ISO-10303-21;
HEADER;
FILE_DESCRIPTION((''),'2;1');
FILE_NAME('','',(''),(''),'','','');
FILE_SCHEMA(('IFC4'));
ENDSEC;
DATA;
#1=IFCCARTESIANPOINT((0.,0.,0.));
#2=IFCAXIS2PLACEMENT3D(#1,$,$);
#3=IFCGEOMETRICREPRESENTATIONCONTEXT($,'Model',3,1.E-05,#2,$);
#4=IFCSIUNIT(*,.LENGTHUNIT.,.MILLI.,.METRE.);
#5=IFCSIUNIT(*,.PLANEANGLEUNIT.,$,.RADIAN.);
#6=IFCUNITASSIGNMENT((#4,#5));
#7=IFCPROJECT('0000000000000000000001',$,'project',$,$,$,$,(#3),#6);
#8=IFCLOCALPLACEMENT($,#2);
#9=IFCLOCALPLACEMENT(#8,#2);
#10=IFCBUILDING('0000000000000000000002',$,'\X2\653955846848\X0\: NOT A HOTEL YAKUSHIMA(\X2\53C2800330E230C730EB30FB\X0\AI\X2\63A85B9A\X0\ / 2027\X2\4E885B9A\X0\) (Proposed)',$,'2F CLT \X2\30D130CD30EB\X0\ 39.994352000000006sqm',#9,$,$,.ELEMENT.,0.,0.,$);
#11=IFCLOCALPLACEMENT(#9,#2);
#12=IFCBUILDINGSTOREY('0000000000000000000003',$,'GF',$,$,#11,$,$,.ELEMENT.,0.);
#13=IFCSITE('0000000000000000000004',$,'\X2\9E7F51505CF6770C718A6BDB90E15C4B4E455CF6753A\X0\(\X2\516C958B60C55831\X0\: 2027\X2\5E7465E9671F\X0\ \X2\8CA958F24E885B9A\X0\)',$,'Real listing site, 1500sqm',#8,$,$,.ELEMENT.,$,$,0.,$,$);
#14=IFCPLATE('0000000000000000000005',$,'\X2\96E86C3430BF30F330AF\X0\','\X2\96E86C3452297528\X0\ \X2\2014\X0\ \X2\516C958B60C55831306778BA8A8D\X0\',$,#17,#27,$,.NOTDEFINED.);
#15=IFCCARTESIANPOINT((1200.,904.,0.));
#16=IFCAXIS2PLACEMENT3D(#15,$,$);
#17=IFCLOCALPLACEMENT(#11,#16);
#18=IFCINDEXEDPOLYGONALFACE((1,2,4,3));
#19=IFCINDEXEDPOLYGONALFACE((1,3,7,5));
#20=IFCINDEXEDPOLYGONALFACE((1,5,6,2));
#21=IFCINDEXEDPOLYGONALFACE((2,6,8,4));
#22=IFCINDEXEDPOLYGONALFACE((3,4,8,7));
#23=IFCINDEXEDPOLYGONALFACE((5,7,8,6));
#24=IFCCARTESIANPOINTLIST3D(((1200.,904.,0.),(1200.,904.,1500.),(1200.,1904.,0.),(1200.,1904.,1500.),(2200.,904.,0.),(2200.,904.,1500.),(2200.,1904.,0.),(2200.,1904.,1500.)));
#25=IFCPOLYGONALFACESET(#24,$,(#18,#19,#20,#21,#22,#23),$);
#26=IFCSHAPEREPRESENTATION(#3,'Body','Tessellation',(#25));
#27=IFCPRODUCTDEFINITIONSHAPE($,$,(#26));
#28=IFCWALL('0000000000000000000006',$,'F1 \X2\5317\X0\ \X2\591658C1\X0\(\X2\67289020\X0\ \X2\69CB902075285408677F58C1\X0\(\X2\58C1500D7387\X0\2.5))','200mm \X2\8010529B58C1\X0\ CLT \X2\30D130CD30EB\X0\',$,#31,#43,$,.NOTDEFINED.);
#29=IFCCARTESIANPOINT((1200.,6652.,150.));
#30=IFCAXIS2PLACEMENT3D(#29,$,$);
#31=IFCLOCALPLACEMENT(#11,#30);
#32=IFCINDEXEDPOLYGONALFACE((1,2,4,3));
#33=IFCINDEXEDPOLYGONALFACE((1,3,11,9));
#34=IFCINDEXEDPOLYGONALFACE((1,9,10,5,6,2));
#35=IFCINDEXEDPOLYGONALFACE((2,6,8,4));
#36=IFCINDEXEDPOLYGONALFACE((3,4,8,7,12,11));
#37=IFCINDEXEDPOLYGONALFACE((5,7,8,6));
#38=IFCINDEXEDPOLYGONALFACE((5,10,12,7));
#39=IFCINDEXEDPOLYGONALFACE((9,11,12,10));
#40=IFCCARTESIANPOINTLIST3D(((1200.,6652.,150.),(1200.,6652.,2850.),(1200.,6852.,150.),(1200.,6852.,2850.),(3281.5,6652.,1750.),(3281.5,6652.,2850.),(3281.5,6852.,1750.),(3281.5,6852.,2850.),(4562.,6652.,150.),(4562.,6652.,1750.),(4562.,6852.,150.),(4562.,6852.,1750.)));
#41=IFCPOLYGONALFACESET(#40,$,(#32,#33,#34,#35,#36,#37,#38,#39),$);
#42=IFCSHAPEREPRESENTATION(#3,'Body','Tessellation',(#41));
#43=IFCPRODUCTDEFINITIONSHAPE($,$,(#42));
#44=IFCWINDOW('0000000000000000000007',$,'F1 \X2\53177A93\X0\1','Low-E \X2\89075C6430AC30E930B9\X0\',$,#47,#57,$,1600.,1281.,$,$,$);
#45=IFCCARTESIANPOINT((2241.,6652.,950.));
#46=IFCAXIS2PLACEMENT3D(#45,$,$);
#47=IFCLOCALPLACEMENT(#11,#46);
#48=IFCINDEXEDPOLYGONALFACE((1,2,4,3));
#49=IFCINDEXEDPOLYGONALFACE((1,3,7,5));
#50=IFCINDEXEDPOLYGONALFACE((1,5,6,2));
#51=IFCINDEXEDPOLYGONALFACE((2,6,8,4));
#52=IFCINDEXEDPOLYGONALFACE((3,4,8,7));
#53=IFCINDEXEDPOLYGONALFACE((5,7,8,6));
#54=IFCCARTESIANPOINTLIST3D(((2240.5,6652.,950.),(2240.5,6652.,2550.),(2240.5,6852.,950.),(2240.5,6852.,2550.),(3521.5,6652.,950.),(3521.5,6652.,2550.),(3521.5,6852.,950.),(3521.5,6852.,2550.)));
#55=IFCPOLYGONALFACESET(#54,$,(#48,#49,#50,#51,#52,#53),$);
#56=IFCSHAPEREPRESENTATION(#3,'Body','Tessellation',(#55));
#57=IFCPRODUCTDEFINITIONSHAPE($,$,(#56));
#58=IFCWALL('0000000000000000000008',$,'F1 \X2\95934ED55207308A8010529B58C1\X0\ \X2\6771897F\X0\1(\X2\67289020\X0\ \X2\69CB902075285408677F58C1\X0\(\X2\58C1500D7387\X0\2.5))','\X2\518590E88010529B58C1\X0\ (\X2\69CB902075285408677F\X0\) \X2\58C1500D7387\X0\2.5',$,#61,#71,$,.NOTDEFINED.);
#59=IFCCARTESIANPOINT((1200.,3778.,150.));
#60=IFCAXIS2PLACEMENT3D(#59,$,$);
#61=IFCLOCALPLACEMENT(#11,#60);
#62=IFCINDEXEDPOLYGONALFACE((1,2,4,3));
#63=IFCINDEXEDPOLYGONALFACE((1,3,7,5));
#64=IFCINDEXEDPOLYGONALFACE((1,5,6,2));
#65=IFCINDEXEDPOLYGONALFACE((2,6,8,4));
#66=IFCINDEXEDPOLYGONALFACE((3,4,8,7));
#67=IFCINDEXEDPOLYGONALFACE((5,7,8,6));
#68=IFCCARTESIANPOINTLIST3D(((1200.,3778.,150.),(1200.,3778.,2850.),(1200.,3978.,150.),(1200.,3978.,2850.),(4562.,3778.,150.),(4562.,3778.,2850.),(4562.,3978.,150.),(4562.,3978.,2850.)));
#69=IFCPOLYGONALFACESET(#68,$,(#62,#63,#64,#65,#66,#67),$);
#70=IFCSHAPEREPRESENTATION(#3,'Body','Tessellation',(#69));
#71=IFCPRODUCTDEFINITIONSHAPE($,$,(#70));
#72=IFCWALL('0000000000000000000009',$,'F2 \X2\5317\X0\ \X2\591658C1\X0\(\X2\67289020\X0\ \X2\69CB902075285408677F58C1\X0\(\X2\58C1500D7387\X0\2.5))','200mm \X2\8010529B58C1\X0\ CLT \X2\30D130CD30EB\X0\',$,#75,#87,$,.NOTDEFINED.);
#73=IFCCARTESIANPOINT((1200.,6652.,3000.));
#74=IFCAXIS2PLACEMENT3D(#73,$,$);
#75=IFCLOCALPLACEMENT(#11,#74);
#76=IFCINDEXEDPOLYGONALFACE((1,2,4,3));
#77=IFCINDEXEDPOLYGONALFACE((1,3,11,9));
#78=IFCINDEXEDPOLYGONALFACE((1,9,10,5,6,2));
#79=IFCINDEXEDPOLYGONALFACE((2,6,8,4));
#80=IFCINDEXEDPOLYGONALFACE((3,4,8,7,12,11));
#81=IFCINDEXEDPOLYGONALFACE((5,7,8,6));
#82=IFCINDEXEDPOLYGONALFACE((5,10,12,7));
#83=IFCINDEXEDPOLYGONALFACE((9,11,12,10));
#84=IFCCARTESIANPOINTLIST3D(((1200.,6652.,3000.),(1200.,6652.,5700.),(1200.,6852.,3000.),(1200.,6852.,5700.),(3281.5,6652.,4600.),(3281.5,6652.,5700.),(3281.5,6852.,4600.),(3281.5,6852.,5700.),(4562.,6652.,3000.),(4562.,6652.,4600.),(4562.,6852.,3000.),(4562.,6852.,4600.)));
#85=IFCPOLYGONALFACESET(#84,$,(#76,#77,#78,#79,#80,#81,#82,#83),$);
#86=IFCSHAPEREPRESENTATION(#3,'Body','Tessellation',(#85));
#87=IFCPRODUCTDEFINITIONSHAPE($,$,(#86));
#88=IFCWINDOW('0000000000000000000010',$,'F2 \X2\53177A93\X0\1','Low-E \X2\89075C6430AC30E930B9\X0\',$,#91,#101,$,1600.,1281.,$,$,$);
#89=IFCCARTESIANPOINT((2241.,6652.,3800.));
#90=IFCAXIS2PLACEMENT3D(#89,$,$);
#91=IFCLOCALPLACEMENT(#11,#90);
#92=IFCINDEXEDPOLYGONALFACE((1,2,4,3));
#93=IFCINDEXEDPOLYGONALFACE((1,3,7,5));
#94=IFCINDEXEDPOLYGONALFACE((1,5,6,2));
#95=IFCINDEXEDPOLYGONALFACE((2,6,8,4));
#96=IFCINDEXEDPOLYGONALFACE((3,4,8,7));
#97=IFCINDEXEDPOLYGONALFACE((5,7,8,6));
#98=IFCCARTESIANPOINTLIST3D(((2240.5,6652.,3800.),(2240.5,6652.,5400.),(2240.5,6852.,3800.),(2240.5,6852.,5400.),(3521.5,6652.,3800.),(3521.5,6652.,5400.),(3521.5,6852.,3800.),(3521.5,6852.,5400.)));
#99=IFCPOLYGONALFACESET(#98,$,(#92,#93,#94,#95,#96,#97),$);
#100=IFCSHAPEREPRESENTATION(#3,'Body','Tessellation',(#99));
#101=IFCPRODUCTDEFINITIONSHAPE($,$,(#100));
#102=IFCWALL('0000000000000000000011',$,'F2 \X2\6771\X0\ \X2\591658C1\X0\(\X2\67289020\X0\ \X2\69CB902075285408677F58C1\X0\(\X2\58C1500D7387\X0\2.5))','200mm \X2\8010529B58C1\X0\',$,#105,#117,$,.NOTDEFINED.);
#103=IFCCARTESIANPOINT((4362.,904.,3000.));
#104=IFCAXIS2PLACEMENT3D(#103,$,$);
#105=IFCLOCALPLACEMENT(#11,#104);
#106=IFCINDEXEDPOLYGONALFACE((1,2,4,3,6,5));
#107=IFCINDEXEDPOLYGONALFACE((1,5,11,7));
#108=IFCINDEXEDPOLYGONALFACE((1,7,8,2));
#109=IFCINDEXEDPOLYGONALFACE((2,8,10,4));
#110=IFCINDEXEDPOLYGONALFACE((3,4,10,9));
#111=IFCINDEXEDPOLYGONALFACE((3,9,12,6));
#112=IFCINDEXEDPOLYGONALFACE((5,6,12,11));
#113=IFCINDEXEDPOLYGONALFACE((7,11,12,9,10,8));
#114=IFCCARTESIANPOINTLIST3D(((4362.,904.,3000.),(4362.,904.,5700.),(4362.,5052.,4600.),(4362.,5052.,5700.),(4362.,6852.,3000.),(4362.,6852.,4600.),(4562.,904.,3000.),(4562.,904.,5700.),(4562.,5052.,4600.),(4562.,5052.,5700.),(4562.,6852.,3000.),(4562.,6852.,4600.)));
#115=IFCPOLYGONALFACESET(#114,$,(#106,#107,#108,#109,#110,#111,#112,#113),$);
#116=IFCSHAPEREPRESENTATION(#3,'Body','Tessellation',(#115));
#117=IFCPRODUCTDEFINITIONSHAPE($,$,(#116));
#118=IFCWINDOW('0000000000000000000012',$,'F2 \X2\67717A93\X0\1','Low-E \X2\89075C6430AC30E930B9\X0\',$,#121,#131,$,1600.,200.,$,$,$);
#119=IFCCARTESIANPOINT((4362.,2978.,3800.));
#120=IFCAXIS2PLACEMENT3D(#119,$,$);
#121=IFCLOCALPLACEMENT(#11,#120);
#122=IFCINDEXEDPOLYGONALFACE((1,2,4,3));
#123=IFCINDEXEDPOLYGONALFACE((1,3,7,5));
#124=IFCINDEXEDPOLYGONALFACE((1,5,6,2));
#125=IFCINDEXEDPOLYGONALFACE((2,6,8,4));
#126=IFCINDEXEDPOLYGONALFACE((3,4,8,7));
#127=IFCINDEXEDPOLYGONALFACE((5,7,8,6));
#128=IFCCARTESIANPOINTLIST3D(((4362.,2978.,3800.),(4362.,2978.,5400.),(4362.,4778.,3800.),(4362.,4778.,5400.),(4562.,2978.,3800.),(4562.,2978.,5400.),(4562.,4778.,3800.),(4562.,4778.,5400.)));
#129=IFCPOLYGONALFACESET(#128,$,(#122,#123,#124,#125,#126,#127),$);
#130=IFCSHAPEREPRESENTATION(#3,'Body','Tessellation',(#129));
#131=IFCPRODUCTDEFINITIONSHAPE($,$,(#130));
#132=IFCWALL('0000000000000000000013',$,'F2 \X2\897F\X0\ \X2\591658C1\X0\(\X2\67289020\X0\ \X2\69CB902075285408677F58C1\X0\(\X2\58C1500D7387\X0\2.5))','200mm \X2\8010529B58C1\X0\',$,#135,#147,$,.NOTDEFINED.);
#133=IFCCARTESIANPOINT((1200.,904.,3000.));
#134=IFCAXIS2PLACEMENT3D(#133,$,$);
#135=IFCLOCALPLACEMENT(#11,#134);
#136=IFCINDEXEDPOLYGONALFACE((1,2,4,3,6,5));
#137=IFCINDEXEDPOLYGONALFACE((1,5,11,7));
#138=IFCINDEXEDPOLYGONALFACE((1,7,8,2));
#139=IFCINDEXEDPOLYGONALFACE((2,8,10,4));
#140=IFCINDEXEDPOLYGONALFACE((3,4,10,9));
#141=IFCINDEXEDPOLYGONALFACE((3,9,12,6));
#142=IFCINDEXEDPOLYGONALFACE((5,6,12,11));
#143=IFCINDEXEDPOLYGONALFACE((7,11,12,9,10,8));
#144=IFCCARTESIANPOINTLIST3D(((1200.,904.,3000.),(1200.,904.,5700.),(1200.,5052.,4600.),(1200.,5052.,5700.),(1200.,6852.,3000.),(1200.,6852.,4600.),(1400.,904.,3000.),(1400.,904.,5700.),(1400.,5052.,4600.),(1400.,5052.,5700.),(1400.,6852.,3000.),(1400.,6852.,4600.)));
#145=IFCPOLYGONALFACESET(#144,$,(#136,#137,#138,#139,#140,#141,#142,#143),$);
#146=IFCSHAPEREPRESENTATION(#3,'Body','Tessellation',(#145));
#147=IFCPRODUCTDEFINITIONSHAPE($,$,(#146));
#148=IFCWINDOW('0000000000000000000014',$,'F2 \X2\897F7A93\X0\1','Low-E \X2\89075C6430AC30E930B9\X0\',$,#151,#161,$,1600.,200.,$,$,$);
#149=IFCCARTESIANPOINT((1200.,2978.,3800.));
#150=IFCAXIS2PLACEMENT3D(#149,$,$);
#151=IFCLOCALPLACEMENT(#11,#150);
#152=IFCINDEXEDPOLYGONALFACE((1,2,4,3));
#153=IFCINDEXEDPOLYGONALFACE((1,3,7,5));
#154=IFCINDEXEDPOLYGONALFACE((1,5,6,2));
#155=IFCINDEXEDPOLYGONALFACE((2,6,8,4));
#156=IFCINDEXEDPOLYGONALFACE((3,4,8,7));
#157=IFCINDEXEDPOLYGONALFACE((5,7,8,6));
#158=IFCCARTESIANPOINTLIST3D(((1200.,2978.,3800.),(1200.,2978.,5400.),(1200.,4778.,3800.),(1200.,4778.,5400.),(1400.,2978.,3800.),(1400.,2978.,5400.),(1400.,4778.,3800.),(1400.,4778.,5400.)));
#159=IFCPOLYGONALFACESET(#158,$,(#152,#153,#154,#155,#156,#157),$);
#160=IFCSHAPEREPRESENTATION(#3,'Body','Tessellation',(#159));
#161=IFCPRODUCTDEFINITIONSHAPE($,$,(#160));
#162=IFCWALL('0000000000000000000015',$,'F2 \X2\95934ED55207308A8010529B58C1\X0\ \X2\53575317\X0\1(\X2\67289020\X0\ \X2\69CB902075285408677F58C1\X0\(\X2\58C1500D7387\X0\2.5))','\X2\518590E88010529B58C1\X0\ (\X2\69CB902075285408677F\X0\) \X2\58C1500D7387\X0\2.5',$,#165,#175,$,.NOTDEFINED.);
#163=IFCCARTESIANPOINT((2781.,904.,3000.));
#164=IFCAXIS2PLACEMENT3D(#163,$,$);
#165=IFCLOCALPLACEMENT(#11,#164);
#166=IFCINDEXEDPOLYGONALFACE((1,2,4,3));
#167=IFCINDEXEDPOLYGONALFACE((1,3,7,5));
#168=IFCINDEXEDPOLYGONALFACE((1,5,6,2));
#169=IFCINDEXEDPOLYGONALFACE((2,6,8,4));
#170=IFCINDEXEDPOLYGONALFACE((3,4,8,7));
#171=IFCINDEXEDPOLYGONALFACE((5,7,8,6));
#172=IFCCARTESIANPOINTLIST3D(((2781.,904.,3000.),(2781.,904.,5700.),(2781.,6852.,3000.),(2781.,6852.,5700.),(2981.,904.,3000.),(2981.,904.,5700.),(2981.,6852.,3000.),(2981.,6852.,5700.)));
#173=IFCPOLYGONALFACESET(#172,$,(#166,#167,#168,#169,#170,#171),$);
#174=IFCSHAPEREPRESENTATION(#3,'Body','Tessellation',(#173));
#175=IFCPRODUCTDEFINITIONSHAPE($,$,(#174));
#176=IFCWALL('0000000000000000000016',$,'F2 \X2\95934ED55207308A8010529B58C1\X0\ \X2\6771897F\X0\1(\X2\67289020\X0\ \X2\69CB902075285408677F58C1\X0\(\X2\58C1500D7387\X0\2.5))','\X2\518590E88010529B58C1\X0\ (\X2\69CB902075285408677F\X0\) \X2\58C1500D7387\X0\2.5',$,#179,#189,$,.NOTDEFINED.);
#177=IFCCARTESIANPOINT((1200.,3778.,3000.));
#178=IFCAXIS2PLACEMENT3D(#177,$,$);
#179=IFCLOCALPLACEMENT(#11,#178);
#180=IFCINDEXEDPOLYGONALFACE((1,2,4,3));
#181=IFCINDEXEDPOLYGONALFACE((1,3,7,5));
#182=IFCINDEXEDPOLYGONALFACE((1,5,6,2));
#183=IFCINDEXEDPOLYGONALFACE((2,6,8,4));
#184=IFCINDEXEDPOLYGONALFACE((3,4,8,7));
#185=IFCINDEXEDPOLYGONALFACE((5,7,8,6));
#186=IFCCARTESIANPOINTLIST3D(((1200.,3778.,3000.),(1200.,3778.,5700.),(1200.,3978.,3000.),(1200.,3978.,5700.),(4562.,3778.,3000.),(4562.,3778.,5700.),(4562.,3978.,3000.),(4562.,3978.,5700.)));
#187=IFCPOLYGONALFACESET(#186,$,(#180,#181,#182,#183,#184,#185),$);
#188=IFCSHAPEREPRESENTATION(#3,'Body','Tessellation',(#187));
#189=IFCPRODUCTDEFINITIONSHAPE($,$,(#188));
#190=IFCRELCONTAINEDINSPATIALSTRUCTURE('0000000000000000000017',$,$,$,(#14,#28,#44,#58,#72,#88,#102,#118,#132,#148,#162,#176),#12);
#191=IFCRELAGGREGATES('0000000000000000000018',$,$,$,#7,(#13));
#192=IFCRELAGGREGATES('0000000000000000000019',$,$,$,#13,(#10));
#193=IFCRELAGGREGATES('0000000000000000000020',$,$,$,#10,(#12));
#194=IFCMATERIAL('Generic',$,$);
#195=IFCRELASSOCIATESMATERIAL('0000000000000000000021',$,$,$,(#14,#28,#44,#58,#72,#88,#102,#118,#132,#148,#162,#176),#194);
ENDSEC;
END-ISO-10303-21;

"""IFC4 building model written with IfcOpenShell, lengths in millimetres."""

from ifc_helpers import new_model, si_unit, frame, frame_2d, origin, place, context, project, spatial, rectangle, extrude, material, element, fill, save


model = new_model("IFC4")

# Units and contexts
model_context = context("Model", 3, precision=1e-05, world=origin())
ifc_project = project(units=[si_unit("LENGTHUNIT", "METRE", prefix="MILLI"), si_unit("PLANEANGLEUNIT", "RADIAN")], contexts=[model_context])

# Site, building, storey
site_placement = place(None, origin())
site = spatial("IfcSite", under=ifc_project, at=site_placement, Name="鹿児島県熊毛郡屋久島町(公開情報: 2027年早期 販売予定)", ObjectType="Real listing site, 1500sqm", CompositionType="ELEMENT", RefElevation=0.0)
building_placement = place(site_placement, origin())
building = spatial("IfcBuilding", under=site, at=building_placement, Name="改善案: NOT A HOTEL YAKUSHIMA(参考モデル・AI推定 / 2027予定) (Proposed)", ObjectType="2F CLT パネル 39.994352000000006sqm", CompositionType="ELEMENT", ElevationOfRefHeight=0.0, ElevationOfTerrain=0.0)
storey_placement = place(building_placement, origin())
storey = spatial("IfcBuildingStorey", under=building, at=storey_placement, Name="GF", CompositionType="ELEMENT", Elevation=0.0)

# Plate
ifc_material_1 = material(Name="Generic")
plate_placement = place(storey_placement, frame((1200.0, 904.0, 0.0)))
element("IfcPlate", 1, at=plate_placement, inside=storey, material=ifc_material_1, Name="雨水タンク", Description="雨水利用 — 公開情報で確認", PredefinedType="NOTDEFINED", context=model_context, shape_type="SweptSolid", body=[
    extrude(rectangle(XDim=1000.0, YDim=1000.0, at=frame_2d((500.0, 500.0))), frame((1200.0, 904.0, 0.0)), (0.0, 0.0, 1.0), 1500.0),
])

# Wall, opening, window
wall_1_placement = place(storey_placement, frame((1200.0, 6652.0, 150.0)))
wall_1 = element("IfcWall", 2, at=wall_1_placement, inside=storey, material=ifc_material_1, Name="F1 北 外壁(木造 構造用合板壁(壁倍率2.5))", Description="200mm 耐力壁 CLT パネル", PredefinedType="NOTDEFINED", context=model_context, shape_type="SweptSolid", body=[
    extrude(rectangle(XDim=3362.0, YDim=200.0, at=frame_2d((1681.0, 100.0))), frame((1200.0, 6652.0, 150.0)), (0.0, 0.0, 1.0), 2700.0),
])
opening_1_placement = place(storey_placement, frame((2241.0, 6652.0, 950.0)))
opening_1 = element("IfcOpeningElement", 3, at=opening_1_placement, cuts=wall_1, PredefinedType="NOTDEFINED", context=model_context, shape_type="SweptSolid", body=[
    extrude(rectangle(XDim=1281.0, YDim=200.0, at=frame_2d((640.0, 100.0))), frame((2241.0, 6652.0, 950.0)), (0.0, 0.0, 1.0), 1600.0),
])
window_1_placement = place(storey_placement, frame((2241.0, 6652.0, 950.0)))
window_1 = element("IfcWindow", 4, at=window_1_placement, inside=storey, material=ifc_material_1, Name="F1 北窓1", Description="Low-E 複層ガラス", OverallHeight=1600.0, OverallWidth=1281.0, context=model_context, shape_type="SweptSolid", body=[
    extrude(rectangle(XDim=1281.0, YDim=200.0, at=frame_2d((640.0, 100.0))), frame((2241.0, 6652.0, 950.0)), (0.0, 0.0, 1.0), 1600.0),
])
fill(opening_1, window_1)

# Wall
wall_2_placement = place(storey_placement, frame((1200.0, 3778.0, 150.0)))
element("IfcWall", 5, at=wall_2_placement, inside=storey, material=ifc_material_1, Name="F1 間仕切り耐力壁 東西1(木造 構造用合板壁(壁倍率2.5))", Description="内部耐力壁 (構造用合板) 壁倍率2.5", PredefinedType="NOTDEFINED", context=model_context, shape_type="SweptSolid", body=[
    extrude(rectangle(XDim=3362.0, YDim=200.0, at=frame_2d((1681.0, 100.0))), frame((1200.0, 3778.0, 150.0)), (0.0, 0.0, 1.0), 2700.0),
])

# Walls, openings, windows
wall_3_placement = place(storey_placement, frame((1200.0, 6652.0, 3000.0)))
wall_3 = element("IfcWall", 6, at=wall_3_placement, inside=storey, material=ifc_material_1, Name="F2 北 外壁(木造 構造用合板壁(壁倍率2.5))", Description="200mm 耐力壁 CLT パネル", PredefinedType="NOTDEFINED", context=model_context, shape_type="SweptSolid", body=[
    extrude(rectangle(XDim=3362.0, YDim=200.0, at=frame_2d((1681.0, 100.0))), frame((1200.0, 6652.0, 3000.0)), (0.0, 0.0, 1.0), 2700.0),
])
opening_2_placement = place(storey_placement, frame((2241.0, 6652.0, 3800.0)))
opening_2 = element("IfcOpeningElement", 7, at=opening_2_placement, cuts=wall_3, PredefinedType="NOTDEFINED", context=model_context, shape_type="SweptSolid", body=[
    extrude(rectangle(XDim=1281.0, YDim=200.0, at=frame_2d((640.0, 100.0))), frame((2241.0, 6652.0, 3800.0)), (0.0, 0.0, 1.0), 1600.0),
])
window_2_placement = place(storey_placement, frame((2241.0, 6652.0, 3800.0)))
window_2 = element("IfcWindow", 8, at=window_2_placement, inside=storey, material=ifc_material_1, Name="F2 北窓1", Description="Low-E 複層ガラス", OverallHeight=1600.0, OverallWidth=1281.0, context=model_context, shape_type="SweptSolid", body=[
    extrude(rectangle(XDim=1281.0, YDim=200.0, at=frame_2d((640.0, 100.0))), frame((2241.0, 6652.0, 3800.0)), (0.0, 0.0, 1.0), 1600.0),
])
fill(opening_2, window_2)
wall_4_placement = place(storey_placement, frame((4362.0, 904.0, 3000.0)))
wall_4 = element("IfcWall", 9, at=wall_4_placement, inside=storey, material=ifc_material_1, Name="F2 東 外壁(木造 構造用合板壁(壁倍率2.5))", Description="200mm 耐力壁", PredefinedType="NOTDEFINED", context=model_context, shape_type="SweptSolid", body=[
    extrude(rectangle(XDim=200.0, YDim=5948.0, at=frame_2d((100.0, 2974.0))), frame((4362.0, 904.0, 3000.0)), (0.0, 0.0, 1.0), 2700.0),
])
opening_3_placement = place(storey_placement, frame((4362.0, 2978.0, 3800.0)))
opening_3 = element("IfcOpeningElement", 10, at=opening_3_placement, cuts=wall_4, PredefinedType="NOTDEFINED", context=model_context, shape_type="SweptSolid", body=[
    extrude(rectangle(XDim=200.0, YDim=1800.0, at=frame_2d((100.0, 900.0))), frame((4362.0, 2978.0, 3800.0)), (0.0, 0.0, 1.0), 1600.0),
])
window_3_placement = place(storey_placement, frame((4362.0, 2978.0, 3800.0)))
window_3 = element("IfcWindow", 11, at=window_3_placement, inside=storey, material=ifc_material_1, Name="F2 東窓1", Description="Low-E 複層ガラス", OverallHeight=1600.0, OverallWidth=200.0, context=model_context, shape_type="SweptSolid", body=[
    extrude(rectangle(XDim=200.0, YDim=1800.0, at=frame_2d((100.0, 900.0))), frame((4362.0, 2978.0, 3800.0)), (0.0, 0.0, 1.0), 1600.0),
])
fill(opening_3, window_3)
wall_5_placement = place(storey_placement, frame((1200.0, 904.0, 3000.0)))
wall_5 = element("IfcWall", 12, at=wall_5_placement, inside=storey, material=ifc_material_1, Name="F2 西 外壁(木造 構造用合板壁(壁倍率2.5))", Description="200mm 耐力壁", PredefinedType="NOTDEFINED", context=model_context, shape_type="SweptSolid", body=[
    extrude(rectangle(XDim=200.0, YDim=5948.0, at=frame_2d((100.0, 2974.0))), frame((1200.0, 904.0, 3000.0)), (0.0, 0.0, 1.0), 2700.0),
])
opening_4_placement = place(storey_placement, frame((1200.0, 2978.0, 3800.0)))
opening_4 = element("IfcOpeningElement", 13, at=opening_4_placement, cuts=wall_5, PredefinedType="NOTDEFINED", context=model_context, shape_type="SweptSolid", body=[
    extrude(rectangle(XDim=200.0, YDim=1800.0, at=frame_2d((100.0, 900.0))), frame((1200.0, 2978.0, 3800.0)), (0.0, 0.0, 1.0), 1600.0),
])
window_4_placement = place(storey_placement, frame((1200.0, 2978.0, 3800.0)))
window_4 = element("IfcWindow", 14, at=window_4_placement, inside=storey, material=ifc_material_1, Name="F2 西窓1", Description="Low-E 複層ガラス", OverallHeight=1600.0, OverallWidth=200.0, context=model_context, shape_type="SweptSolid", body=[
    extrude(rectangle(XDim=200.0, YDim=1800.0, at=frame_2d((100.0, 900.0))), frame((1200.0, 2978.0, 3800.0)), (0.0, 0.0, 1.0), 1600.0),
])
fill(opening_4, window_4)

# Walls
wall_6_placement = place(storey_placement, frame((2781.0, 904.0, 3000.0)))
element("IfcWall", 15, at=wall_6_placement, inside=storey, material=ifc_material_1, Name="F2 間仕切り耐力壁 南北1(木造 構造用合板壁(壁倍率2.5))", Description="内部耐力壁 (構造用合板) 壁倍率2.5", PredefinedType="NOTDEFINED", context=model_context, shape_type="SweptSolid", body=[
    extrude(rectangle(XDim=200.0, YDim=5948.0, at=frame_2d((100.0, 2974.0))), frame((2781.0, 904.0, 3000.0)), (0.0, 0.0, 1.0), 2700.0),
])
wall_7_placement = place(storey_placement, frame((1200.0, 3778.0, 3000.0)))
element("IfcWall", 16, at=wall_7_placement, inside=storey, material=ifc_material_1, Name="F2 間仕切り耐力壁 東西1(木造 構造用合板壁(壁倍率2.5))", Description="内部耐力壁 (構造用合板) 壁倍率2.5", PredefinedType="NOTDEFINED", context=model_context, shape_type="SweptSolid", body=[
    extrude(rectangle(XDim=3362.0, YDim=200.0, at=frame_2d((1681.0, 100.0))), frame((1200.0, 3778.0, 3000.0)), (0.0, 0.0, 1.0), 2700.0),
])

save(model, "model.ifc")
